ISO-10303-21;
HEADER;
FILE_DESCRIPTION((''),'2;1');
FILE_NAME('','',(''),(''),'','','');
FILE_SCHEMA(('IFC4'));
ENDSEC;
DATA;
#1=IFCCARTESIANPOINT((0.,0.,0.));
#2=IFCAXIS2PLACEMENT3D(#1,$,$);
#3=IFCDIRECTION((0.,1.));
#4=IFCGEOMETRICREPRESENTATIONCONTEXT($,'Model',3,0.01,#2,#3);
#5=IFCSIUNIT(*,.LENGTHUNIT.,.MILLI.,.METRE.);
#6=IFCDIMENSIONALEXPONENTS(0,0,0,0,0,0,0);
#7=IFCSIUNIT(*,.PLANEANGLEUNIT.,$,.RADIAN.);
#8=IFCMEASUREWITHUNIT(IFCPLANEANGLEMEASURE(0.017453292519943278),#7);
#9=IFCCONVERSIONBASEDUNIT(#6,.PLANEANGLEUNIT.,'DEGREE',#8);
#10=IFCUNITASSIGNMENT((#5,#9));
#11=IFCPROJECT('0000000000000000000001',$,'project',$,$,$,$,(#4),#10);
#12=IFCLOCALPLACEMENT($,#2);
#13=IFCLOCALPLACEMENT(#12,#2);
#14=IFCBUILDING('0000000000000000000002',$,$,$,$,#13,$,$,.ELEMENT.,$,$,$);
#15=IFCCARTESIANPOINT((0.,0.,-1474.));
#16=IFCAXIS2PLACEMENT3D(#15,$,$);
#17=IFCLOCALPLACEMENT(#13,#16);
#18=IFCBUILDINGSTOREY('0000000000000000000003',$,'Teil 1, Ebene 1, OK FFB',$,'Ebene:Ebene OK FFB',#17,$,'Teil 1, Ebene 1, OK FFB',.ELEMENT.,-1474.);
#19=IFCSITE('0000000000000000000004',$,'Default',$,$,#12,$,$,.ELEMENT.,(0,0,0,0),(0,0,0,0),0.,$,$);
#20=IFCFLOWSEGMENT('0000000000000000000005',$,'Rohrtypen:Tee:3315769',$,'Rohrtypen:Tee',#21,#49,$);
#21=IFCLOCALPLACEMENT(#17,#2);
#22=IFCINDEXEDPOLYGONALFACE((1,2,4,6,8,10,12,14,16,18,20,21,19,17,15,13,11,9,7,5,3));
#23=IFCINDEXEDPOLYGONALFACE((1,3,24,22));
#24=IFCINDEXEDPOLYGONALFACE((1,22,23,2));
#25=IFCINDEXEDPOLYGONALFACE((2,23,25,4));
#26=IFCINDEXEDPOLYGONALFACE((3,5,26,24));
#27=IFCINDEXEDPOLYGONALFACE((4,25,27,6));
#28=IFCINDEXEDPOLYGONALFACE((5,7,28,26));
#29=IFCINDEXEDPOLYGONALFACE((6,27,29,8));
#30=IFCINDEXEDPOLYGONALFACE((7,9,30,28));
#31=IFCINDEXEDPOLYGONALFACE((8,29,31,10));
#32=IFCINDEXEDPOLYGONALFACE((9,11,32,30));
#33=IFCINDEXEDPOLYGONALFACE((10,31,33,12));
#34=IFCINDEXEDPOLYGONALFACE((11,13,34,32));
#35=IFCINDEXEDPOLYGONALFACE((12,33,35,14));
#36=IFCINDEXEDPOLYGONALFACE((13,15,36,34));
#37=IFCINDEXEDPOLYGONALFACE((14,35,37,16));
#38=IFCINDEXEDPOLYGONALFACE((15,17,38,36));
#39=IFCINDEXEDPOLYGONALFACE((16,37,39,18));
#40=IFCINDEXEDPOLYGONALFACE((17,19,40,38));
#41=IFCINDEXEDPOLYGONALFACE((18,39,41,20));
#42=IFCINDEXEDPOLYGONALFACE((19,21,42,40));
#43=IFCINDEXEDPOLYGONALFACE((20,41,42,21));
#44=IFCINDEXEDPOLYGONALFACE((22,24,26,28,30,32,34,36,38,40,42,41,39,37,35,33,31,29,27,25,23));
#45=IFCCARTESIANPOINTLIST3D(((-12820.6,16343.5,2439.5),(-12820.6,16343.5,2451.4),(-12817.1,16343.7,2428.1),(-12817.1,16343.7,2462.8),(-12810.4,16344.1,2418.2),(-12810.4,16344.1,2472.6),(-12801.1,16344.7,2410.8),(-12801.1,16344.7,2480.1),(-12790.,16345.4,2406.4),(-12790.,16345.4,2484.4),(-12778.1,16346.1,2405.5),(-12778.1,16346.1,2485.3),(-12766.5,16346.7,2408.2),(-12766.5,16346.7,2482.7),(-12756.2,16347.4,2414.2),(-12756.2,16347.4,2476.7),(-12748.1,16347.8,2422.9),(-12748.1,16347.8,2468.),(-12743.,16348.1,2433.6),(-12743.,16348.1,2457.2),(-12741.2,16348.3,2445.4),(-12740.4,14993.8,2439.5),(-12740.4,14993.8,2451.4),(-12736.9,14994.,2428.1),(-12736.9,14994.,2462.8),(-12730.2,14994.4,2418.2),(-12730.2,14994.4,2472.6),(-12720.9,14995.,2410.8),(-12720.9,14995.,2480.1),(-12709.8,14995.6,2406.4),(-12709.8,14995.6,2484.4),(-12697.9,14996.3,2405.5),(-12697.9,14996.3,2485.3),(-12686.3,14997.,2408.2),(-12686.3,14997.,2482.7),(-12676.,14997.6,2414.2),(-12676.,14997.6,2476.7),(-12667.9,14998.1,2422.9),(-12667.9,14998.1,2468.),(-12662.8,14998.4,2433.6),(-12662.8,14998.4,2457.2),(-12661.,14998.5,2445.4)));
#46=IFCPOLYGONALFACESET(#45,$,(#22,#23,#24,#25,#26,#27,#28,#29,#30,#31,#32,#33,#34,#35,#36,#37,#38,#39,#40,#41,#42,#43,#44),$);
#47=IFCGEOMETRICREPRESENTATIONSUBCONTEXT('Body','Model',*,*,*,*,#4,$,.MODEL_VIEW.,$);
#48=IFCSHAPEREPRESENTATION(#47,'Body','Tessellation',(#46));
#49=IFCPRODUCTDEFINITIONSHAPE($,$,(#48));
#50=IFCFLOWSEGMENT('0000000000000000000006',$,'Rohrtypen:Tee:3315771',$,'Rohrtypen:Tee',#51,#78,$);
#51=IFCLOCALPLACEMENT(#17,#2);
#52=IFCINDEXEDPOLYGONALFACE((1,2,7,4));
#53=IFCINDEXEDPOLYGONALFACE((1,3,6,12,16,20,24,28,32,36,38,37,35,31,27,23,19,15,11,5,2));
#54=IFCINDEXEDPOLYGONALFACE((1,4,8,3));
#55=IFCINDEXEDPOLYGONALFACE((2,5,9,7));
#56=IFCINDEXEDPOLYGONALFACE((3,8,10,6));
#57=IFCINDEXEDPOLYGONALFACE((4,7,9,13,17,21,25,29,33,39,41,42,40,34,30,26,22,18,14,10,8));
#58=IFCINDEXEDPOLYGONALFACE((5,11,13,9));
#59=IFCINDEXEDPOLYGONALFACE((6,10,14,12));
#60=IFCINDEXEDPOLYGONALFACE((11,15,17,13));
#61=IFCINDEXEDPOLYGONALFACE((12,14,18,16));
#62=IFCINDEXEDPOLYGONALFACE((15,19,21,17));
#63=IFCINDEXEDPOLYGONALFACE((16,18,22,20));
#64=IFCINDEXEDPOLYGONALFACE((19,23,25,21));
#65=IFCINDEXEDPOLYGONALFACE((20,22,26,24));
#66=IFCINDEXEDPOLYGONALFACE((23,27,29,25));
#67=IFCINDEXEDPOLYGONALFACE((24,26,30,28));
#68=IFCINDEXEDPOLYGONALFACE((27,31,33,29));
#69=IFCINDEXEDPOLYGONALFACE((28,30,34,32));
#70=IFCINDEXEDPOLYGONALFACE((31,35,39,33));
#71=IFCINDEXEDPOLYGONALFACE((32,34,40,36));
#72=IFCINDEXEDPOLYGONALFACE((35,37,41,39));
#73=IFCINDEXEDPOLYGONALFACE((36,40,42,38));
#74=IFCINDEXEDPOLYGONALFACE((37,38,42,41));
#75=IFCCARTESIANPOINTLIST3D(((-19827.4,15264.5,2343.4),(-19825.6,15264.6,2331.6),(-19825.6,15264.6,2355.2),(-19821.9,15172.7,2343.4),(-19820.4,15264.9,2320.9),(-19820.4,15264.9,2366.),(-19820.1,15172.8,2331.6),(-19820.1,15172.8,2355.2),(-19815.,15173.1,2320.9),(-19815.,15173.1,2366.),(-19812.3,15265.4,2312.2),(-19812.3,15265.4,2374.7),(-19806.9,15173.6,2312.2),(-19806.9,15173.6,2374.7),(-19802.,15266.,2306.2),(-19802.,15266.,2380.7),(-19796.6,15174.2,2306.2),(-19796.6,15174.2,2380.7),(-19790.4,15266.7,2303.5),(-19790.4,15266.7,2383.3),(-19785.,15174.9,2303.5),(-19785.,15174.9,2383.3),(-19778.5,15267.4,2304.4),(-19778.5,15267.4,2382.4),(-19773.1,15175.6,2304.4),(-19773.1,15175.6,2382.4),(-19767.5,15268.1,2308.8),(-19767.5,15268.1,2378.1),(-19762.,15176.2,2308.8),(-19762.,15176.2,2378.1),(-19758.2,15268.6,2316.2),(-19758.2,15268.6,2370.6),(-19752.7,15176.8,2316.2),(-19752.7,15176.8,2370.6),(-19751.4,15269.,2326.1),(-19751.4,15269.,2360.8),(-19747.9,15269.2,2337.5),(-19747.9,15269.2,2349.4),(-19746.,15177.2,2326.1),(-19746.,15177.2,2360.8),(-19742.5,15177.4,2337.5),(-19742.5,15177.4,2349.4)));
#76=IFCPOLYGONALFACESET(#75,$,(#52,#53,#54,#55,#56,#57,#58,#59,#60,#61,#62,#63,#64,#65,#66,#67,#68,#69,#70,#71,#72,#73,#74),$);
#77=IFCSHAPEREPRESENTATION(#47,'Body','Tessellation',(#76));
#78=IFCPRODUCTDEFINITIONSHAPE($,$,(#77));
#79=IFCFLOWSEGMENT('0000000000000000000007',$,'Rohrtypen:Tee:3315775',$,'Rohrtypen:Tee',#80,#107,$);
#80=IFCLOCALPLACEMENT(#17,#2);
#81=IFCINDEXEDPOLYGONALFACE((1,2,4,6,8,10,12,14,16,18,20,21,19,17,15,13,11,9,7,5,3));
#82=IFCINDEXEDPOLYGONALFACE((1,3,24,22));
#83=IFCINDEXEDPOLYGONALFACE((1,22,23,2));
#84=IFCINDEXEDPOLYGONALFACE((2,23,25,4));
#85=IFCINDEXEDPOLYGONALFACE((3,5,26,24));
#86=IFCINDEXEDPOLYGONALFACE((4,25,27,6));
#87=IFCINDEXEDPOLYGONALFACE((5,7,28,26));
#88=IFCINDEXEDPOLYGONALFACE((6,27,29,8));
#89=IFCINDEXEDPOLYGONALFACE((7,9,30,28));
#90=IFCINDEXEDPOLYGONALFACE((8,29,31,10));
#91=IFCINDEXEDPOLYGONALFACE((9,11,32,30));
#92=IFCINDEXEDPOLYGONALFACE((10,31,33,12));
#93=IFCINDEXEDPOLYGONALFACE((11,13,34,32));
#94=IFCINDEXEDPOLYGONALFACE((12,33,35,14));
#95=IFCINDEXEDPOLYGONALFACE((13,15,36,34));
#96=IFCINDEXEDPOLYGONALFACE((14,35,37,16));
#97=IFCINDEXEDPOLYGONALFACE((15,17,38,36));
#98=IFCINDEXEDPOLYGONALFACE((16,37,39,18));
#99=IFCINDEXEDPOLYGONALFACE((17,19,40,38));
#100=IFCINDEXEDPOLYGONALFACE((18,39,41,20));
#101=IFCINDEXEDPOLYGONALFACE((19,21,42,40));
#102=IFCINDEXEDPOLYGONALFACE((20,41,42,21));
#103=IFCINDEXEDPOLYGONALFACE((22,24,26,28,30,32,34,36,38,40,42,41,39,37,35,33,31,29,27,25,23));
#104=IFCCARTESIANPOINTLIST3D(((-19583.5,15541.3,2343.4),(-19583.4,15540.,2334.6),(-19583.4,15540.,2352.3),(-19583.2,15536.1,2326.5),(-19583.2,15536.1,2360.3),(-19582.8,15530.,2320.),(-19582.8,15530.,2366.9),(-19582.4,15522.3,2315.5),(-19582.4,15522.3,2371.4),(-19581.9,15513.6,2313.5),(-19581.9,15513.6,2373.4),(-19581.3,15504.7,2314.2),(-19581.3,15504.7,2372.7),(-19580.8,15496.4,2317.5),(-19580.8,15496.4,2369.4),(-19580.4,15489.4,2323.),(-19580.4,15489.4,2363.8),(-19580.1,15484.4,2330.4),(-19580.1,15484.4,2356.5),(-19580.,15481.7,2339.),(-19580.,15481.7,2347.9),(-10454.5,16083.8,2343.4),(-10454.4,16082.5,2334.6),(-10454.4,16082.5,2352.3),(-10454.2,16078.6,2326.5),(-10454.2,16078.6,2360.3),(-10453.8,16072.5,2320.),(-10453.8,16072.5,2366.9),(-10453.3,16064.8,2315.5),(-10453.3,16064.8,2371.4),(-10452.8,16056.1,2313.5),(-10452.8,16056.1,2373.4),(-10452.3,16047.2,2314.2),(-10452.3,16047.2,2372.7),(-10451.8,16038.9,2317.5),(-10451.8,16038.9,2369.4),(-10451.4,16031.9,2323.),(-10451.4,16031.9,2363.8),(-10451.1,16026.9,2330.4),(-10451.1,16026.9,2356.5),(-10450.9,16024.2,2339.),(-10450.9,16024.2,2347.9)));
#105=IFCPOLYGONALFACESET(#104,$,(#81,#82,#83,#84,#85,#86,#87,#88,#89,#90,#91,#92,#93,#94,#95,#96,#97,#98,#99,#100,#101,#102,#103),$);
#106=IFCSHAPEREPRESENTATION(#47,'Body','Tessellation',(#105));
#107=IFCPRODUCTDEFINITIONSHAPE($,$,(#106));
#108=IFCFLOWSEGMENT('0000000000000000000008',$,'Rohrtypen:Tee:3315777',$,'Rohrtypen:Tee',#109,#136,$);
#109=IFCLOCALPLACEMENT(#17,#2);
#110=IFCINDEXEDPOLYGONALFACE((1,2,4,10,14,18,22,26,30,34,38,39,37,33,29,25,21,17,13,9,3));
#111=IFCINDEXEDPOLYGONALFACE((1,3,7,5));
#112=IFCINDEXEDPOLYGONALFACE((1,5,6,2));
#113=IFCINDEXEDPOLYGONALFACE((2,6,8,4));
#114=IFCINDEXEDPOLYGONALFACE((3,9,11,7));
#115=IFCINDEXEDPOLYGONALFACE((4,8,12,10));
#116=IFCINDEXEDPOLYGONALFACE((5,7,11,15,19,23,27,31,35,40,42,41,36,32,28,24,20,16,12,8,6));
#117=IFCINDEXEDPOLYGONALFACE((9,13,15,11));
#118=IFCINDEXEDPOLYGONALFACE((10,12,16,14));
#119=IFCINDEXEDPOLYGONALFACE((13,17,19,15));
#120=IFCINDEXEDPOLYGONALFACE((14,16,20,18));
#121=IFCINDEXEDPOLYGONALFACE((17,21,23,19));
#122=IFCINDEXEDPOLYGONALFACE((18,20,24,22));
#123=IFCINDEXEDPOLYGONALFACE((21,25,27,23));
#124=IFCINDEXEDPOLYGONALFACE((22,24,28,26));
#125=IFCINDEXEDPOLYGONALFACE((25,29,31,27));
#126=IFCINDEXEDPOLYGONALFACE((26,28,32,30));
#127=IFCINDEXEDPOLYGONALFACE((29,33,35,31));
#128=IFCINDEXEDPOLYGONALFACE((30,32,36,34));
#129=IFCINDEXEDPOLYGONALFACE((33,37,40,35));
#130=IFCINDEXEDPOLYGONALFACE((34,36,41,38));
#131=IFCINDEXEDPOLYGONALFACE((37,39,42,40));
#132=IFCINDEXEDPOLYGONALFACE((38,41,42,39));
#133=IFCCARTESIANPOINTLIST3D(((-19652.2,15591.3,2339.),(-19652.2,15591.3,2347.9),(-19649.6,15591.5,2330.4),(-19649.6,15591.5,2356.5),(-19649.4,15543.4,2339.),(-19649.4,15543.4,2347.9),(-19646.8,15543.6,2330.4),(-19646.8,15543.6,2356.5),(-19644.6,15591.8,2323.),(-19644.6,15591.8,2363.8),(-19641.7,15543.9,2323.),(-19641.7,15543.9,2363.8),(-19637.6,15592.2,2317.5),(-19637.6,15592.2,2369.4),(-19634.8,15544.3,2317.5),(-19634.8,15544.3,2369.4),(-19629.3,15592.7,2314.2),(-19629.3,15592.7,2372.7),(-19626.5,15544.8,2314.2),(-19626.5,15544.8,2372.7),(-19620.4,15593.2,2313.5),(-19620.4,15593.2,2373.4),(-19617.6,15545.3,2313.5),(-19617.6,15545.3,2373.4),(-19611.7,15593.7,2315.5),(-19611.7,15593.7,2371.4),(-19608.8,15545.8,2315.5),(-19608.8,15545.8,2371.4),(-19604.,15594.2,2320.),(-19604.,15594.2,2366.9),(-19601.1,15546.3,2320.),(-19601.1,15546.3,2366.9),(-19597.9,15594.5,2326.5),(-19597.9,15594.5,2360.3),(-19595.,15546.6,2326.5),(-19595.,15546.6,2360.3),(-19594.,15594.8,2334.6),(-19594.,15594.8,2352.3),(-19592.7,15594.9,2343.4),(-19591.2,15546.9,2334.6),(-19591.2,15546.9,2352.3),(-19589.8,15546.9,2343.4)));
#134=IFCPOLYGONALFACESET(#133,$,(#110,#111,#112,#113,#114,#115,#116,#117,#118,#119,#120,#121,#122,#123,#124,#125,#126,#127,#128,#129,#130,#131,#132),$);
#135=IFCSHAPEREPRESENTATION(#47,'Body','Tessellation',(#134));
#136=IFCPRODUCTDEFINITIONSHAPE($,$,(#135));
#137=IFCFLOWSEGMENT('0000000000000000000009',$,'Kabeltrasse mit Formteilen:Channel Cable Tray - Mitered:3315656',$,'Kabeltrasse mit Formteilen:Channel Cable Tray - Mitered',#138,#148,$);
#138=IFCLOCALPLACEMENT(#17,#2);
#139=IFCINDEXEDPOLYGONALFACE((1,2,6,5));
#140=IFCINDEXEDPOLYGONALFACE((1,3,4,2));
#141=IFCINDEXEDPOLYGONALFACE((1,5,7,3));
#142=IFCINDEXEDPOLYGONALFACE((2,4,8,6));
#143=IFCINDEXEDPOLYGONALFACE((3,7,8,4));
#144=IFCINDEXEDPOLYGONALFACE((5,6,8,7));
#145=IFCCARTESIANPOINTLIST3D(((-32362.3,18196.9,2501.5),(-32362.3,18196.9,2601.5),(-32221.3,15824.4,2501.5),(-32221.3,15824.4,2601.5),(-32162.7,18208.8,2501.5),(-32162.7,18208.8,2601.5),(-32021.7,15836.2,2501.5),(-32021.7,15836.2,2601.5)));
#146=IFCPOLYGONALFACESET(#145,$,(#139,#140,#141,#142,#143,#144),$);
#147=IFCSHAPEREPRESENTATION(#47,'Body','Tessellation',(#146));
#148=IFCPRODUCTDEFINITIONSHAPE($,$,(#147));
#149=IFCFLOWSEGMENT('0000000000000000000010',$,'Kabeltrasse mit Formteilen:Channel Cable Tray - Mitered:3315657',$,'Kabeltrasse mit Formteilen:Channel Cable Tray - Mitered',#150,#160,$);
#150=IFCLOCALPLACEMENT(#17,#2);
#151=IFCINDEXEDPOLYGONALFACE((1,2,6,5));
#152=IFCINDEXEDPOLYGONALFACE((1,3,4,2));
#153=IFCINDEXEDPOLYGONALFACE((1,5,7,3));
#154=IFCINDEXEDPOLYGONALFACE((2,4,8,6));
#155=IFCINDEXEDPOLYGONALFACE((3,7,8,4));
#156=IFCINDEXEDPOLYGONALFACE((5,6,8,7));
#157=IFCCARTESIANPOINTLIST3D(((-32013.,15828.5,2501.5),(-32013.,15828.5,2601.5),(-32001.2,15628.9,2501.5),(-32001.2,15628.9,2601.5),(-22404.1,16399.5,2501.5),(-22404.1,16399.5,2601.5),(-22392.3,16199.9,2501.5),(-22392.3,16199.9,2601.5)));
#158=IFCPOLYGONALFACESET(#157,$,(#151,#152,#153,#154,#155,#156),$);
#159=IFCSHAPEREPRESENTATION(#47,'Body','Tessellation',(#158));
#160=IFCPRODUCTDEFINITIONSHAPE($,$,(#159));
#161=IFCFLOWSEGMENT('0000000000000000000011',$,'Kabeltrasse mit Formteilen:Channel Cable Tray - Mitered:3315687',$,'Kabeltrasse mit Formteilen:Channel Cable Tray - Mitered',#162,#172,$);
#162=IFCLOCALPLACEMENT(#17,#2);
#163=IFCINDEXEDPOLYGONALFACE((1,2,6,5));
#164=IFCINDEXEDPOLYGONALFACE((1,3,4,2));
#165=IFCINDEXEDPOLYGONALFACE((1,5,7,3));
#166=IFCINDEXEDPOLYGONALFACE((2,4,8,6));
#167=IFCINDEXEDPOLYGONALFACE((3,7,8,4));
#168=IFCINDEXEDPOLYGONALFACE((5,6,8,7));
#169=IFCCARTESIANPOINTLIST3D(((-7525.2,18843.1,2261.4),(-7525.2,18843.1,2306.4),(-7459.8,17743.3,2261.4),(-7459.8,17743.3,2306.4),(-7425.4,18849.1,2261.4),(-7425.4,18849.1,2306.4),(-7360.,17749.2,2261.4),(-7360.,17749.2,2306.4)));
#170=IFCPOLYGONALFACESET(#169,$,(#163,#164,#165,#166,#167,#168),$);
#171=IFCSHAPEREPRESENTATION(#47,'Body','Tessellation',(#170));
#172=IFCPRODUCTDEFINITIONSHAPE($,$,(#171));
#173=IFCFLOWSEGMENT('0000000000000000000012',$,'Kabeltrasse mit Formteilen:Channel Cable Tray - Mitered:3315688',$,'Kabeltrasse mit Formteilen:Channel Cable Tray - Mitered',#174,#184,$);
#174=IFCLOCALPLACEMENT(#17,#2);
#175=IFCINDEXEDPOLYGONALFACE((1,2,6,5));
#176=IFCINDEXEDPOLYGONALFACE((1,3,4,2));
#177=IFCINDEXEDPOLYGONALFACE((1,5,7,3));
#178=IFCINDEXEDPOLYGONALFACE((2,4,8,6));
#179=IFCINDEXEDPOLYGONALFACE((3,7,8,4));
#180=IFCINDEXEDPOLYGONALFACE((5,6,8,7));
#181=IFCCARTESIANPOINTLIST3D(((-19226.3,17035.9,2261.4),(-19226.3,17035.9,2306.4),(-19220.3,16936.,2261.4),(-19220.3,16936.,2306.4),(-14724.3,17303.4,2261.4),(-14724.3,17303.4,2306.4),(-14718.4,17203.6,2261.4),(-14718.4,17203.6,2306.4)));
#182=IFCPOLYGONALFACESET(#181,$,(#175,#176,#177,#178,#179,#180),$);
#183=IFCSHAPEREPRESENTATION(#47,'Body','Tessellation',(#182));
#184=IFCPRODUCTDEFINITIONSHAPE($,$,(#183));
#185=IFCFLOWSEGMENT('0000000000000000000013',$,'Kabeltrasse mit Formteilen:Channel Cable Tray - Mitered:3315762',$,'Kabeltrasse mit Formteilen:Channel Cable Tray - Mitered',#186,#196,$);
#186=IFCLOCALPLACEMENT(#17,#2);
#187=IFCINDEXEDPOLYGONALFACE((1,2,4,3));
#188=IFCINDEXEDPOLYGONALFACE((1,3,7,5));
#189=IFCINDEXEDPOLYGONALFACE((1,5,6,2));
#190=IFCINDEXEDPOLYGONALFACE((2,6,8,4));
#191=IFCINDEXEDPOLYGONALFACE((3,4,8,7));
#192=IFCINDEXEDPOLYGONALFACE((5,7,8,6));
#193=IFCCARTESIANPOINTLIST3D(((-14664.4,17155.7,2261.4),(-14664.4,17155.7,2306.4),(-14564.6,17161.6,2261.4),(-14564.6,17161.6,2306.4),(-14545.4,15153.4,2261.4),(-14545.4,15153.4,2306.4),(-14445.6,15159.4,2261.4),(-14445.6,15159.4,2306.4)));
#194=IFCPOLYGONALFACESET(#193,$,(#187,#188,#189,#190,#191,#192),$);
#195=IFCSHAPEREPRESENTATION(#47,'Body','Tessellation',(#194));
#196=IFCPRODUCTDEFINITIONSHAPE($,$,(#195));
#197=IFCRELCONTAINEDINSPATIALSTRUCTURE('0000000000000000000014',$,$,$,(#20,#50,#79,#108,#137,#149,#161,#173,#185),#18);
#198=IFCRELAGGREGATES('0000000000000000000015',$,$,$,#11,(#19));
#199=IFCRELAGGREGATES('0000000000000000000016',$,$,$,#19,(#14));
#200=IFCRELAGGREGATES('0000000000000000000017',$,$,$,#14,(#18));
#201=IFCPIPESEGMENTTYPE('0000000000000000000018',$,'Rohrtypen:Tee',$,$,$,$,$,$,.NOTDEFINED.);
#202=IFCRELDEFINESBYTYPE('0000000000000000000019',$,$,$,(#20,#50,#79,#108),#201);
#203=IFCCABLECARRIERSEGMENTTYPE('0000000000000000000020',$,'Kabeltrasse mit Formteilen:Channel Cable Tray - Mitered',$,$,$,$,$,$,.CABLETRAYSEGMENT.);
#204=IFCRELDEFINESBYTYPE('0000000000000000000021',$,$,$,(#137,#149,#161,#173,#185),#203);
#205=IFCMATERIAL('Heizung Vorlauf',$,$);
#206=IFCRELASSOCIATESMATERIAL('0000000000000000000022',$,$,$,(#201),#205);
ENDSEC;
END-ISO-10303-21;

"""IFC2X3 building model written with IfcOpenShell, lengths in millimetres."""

from ifc_helpers import new_model, entity, si_unit, converted_unit, direction, frame, frame_2d, origin, origin_2d_with_axis, place, context, subcontext, project, spatial, rectangle, circle, extrude, material, type_object, element, save


model = new_model("IFC2X3")

# Units and contexts
model_context = context("Model", 3, precision=0.01, world=origin(), true_north=direction((0.0, 1.0)))
body_context = subcontext(model_context, "Body", "Model", "MODEL_VIEW")
ifc_project = project(units=[si_unit("LENGTHUNIT", "METRE", prefix="MILLI"), converted_unit("PLANEANGLEUNIT", "DEGREE", entity("IfcPlaneAngleMeasure", 0.017453292519943278), si_unit("PLANEANGLEUNIT", "RADIAN"), dimensions=[0, 0, 0, 0, 0, 0, 0])], contexts=[model_context])

# Site, building, storey
site_placement = place(None, origin())
site = spatial("IfcSite", under=ifc_project, at=site_placement, Name="Default", CompositionType="ELEMENT", RefLatitude=(0, 0, 0, 0), RefLongitude=(0, 0, 0, 0), RefElevation=0.0)
building_placement = place(site_placement, origin())
building = spatial("IfcBuilding", under=site, at=building_placement, CompositionType="ELEMENT")
storey_placement = place(building_placement, frame((0.0, 0.0, -1474.0)))
storey = spatial("IfcBuildingStorey", under=building, at=storey_placement, Name="Teil 1, Ebene 1, OK FFB", ObjectType="Ebene:Ebene OK FFB", LongName="Teil 1, Ebene 1, OK FFB", CompositionType="ELEMENT", Elevation=-1474.0)

# Flow segments
ifc_material = material(Name="Heizung Vorlauf")
pipe_segment_type = type_object("IfcPipeSegmentType", Name="Rohrtypen:Tee", PredefinedType="NOTDEFINED", material=ifc_material)
flow_segment_1_placement = place(storey_placement, origin())
element("IfcFlowSegment", 1, at=flow_segment_1_placement, inside=storey, type_object=pipe_segment_type, Name="Rohrtypen:Tee:3315769", ObjectType="Rohrtypen:Tee", context=body_context, shape_type="SweptSolid", body=[
    extrude(circle(Radius=40.0, at=origin_2d_with_axis()), frame((-12700.9, 14996.1, 2445.4), z_axis=(-0.059319, 0.998239, 0.0), x_axis=(0.998239, 0.059319, 0.0)), (0.0, 0.0, 1.0), 1352.1),
])
flow_segment_2_placement = place(storey_placement, origin())
element("IfcFlowSegment", 2, at=flow_segment_2_placement, inside=storey, type_object=pipe_segment_type, Name="Rohrtypen:Tee:3315771", ObjectType="Rohrtypen:Tee", context=body_context, shape_type="SweptSolid", body=[
    extrude(circle(Radius=40.0, at=origin_2d_with_axis()), frame((-19787.4, 15266.9, 2343.4), z_axis=(0.059319, -0.998239, 0.0), x_axis=(-0.998239, -0.059319, 0.0)), (0.0, 0.0, 1.0), 92.0),
])
flow_segment_3_placement = place(storey_placement, origin())
element("IfcFlowSegment", 3, at=flow_segment_3_placement, inside=storey, type_object=pipe_segment_type, Name="Rohrtypen:Tee:3315775", ObjectType="Rohrtypen:Tee", context=body_context, shape_type="SweptSolid", body=[
    extrude(circle(Radius=30.0, at=origin_2d_with_axis()), frame((-19581.7, 15511.4, 2343.4), z_axis=(0.998239, 0.059319, 0.0), x_axis=(-0.059319, 0.998239, 0.0)), (0.0, 0.0, 1.0), 9145.1),
])
flow_segment_4_placement = place(storey_placement, origin())
element("IfcFlowSegment", 4, at=flow_segment_4_placement, inside=storey, type_object=pipe_segment_type, Name="Rohrtypen:Tee:3315777", ObjectType="Rohrtypen:Tee", context=body_context, shape_type="SweptSolid", body=[
    extrude(circle(Radius=30.0, at=origin_2d_with_axis()), frame((-19619.8, 15545.2, 2343.4), z_axis=(-0.059319, 0.998239, 0.0), x_axis=(0.998239, 0.059319, 0.0)), (0.0, 0.0, 1.0), 48.0),
])
cable_carrier_segment_type = type_object("IfcCableCarrierSegmentType", Name="Kabeltrasse mit Formteilen:Channel Cable Tray - Mitered", PredefinedType="CABLETRAYSEGMENT")
flow_segment_5_placement = place(storey_placement, origin())
element("IfcFlowSegment", 5, at=flow_segment_5_placement, inside=storey, type_object=cable_carrier_segment_type, Name="Kabeltrasse mit Formteilen:Channel Cable Tray - Mitered:3315656", ObjectType="Kabeltrasse mit Formteilen:Channel Cable Tray - Mitered", context=body_context, shape_type="SweptSolid", body=[
    extrude(rectangle(XDim=2376.7, YDim=200.0, at=frame_2d((0.0, 0.0), x_axis=(1.0, 0.0))), frame((-32192.0, 17016.6, 2501.5), z_axis=(0.0, 0.0, 1.0), x_axis=(0.059319, -0.998239, 0.0)), (0.0, 0.0, 1.0), 100.0),
])
flow_segment_6_placement = place(storey_placement, origin())
element("IfcFlowSegment", 6, at=flow_segment_6_placement, inside=storey, type_object=cable_carrier_segment_type, Name="Kabeltrasse mit Formteilen:Channel Cable Tray - Mitered:3315657", ObjectType="Kabeltrasse mit Formteilen:Channel Cable Tray - Mitered", context=body_context, shape_type="SweptSolid", body=[
    extrude(rectangle(XDim=9625.8, YDim=200.0, at=frame_2d((0.0, 0.0), x_axis=(1.0, 0.0))), frame((-27202.6, 16014.2, 2501.5), z_axis=(0.0, 0.0, 1.0), x_axis=(0.998239, 0.059319, 0.0)), (0.0, 0.0, 1.0), 100.0),
])
flow_segment_7_placement = place(storey_placement, origin())
element("IfcFlowSegment", 7, at=flow_segment_7_placement, inside=storey, type_object=cable_carrier_segment_type, Name="Kabeltrasse mit Formteilen:Channel Cable Tray - Mitered:3315687", ObjectType="Kabeltrasse mit Formteilen:Channel Cable Tray - Mitered", context=body_context, shape_type="SweptSolid", body=[
    extrude(rectangle(XDim=1101.8, YDim=100.0, at=frame_2d((0.0, 0.0), x_axis=(1.0, 0.0))), frame((-7442.6, 18296.2, 2261.4), z_axis=(0.0, 0.0, 1.0), x_axis=(0.059319, -0.998239, 0.0)), (0.0, 0.0, 1.0), 45.0),
])
flow_segment_8_placement = place(storey_placement, origin())
element("IfcFlowSegment", 8, at=flow_segment_8_placement, inside=storey, type_object=cable_carrier_segment_type, Name="Kabeltrasse mit Formteilen:Channel Cable Tray - Mitered:3315688", ObjectType="Kabeltrasse mit Formteilen:Channel Cable Tray - Mitered", context=body_context, shape_type="SweptSolid", body=[
    extrude(rectangle(XDim=4509.9, YDim=100.0, at=frame_2d((0.0, 0.0), x_axis=(1.0, 0.0))), frame((-16972.3, 17119.7, 2261.4), z_axis=(0.0, 0.0, 1.0), x_axis=(-0.998239, -0.059319, 0.0)), (0.0, 0.0, 1.0), 45.0),
])
flow_segment_9_placement = place(storey_placement, origin())
element("IfcFlowSegment", 9, at=flow_segment_9_placement, inside=storey, type_object=cable_carrier_segment_type, Name="Kabeltrasse mit Formteilen:Channel Cable Tray - Mitered:3315762", ObjectType="Kabeltrasse mit Formteilen:Channel Cable Tray - Mitered", context=body_context, shape_type="SweptSolid", body=[
    extrude(rectangle(XDim=2005.8, YDim=100.0, at=frame_2d((0.0, 0.0), x_axis=(1.0, 0.0))), frame((-14555.0, 16157.5, 2261.4), z_axis=(0.0, 0.0, 1.0), x_axis=(0.059319, -0.998239, 0.0)), (0.0, 0.0, 1.0), 45.0),
])

save(model, "model.ifc")
